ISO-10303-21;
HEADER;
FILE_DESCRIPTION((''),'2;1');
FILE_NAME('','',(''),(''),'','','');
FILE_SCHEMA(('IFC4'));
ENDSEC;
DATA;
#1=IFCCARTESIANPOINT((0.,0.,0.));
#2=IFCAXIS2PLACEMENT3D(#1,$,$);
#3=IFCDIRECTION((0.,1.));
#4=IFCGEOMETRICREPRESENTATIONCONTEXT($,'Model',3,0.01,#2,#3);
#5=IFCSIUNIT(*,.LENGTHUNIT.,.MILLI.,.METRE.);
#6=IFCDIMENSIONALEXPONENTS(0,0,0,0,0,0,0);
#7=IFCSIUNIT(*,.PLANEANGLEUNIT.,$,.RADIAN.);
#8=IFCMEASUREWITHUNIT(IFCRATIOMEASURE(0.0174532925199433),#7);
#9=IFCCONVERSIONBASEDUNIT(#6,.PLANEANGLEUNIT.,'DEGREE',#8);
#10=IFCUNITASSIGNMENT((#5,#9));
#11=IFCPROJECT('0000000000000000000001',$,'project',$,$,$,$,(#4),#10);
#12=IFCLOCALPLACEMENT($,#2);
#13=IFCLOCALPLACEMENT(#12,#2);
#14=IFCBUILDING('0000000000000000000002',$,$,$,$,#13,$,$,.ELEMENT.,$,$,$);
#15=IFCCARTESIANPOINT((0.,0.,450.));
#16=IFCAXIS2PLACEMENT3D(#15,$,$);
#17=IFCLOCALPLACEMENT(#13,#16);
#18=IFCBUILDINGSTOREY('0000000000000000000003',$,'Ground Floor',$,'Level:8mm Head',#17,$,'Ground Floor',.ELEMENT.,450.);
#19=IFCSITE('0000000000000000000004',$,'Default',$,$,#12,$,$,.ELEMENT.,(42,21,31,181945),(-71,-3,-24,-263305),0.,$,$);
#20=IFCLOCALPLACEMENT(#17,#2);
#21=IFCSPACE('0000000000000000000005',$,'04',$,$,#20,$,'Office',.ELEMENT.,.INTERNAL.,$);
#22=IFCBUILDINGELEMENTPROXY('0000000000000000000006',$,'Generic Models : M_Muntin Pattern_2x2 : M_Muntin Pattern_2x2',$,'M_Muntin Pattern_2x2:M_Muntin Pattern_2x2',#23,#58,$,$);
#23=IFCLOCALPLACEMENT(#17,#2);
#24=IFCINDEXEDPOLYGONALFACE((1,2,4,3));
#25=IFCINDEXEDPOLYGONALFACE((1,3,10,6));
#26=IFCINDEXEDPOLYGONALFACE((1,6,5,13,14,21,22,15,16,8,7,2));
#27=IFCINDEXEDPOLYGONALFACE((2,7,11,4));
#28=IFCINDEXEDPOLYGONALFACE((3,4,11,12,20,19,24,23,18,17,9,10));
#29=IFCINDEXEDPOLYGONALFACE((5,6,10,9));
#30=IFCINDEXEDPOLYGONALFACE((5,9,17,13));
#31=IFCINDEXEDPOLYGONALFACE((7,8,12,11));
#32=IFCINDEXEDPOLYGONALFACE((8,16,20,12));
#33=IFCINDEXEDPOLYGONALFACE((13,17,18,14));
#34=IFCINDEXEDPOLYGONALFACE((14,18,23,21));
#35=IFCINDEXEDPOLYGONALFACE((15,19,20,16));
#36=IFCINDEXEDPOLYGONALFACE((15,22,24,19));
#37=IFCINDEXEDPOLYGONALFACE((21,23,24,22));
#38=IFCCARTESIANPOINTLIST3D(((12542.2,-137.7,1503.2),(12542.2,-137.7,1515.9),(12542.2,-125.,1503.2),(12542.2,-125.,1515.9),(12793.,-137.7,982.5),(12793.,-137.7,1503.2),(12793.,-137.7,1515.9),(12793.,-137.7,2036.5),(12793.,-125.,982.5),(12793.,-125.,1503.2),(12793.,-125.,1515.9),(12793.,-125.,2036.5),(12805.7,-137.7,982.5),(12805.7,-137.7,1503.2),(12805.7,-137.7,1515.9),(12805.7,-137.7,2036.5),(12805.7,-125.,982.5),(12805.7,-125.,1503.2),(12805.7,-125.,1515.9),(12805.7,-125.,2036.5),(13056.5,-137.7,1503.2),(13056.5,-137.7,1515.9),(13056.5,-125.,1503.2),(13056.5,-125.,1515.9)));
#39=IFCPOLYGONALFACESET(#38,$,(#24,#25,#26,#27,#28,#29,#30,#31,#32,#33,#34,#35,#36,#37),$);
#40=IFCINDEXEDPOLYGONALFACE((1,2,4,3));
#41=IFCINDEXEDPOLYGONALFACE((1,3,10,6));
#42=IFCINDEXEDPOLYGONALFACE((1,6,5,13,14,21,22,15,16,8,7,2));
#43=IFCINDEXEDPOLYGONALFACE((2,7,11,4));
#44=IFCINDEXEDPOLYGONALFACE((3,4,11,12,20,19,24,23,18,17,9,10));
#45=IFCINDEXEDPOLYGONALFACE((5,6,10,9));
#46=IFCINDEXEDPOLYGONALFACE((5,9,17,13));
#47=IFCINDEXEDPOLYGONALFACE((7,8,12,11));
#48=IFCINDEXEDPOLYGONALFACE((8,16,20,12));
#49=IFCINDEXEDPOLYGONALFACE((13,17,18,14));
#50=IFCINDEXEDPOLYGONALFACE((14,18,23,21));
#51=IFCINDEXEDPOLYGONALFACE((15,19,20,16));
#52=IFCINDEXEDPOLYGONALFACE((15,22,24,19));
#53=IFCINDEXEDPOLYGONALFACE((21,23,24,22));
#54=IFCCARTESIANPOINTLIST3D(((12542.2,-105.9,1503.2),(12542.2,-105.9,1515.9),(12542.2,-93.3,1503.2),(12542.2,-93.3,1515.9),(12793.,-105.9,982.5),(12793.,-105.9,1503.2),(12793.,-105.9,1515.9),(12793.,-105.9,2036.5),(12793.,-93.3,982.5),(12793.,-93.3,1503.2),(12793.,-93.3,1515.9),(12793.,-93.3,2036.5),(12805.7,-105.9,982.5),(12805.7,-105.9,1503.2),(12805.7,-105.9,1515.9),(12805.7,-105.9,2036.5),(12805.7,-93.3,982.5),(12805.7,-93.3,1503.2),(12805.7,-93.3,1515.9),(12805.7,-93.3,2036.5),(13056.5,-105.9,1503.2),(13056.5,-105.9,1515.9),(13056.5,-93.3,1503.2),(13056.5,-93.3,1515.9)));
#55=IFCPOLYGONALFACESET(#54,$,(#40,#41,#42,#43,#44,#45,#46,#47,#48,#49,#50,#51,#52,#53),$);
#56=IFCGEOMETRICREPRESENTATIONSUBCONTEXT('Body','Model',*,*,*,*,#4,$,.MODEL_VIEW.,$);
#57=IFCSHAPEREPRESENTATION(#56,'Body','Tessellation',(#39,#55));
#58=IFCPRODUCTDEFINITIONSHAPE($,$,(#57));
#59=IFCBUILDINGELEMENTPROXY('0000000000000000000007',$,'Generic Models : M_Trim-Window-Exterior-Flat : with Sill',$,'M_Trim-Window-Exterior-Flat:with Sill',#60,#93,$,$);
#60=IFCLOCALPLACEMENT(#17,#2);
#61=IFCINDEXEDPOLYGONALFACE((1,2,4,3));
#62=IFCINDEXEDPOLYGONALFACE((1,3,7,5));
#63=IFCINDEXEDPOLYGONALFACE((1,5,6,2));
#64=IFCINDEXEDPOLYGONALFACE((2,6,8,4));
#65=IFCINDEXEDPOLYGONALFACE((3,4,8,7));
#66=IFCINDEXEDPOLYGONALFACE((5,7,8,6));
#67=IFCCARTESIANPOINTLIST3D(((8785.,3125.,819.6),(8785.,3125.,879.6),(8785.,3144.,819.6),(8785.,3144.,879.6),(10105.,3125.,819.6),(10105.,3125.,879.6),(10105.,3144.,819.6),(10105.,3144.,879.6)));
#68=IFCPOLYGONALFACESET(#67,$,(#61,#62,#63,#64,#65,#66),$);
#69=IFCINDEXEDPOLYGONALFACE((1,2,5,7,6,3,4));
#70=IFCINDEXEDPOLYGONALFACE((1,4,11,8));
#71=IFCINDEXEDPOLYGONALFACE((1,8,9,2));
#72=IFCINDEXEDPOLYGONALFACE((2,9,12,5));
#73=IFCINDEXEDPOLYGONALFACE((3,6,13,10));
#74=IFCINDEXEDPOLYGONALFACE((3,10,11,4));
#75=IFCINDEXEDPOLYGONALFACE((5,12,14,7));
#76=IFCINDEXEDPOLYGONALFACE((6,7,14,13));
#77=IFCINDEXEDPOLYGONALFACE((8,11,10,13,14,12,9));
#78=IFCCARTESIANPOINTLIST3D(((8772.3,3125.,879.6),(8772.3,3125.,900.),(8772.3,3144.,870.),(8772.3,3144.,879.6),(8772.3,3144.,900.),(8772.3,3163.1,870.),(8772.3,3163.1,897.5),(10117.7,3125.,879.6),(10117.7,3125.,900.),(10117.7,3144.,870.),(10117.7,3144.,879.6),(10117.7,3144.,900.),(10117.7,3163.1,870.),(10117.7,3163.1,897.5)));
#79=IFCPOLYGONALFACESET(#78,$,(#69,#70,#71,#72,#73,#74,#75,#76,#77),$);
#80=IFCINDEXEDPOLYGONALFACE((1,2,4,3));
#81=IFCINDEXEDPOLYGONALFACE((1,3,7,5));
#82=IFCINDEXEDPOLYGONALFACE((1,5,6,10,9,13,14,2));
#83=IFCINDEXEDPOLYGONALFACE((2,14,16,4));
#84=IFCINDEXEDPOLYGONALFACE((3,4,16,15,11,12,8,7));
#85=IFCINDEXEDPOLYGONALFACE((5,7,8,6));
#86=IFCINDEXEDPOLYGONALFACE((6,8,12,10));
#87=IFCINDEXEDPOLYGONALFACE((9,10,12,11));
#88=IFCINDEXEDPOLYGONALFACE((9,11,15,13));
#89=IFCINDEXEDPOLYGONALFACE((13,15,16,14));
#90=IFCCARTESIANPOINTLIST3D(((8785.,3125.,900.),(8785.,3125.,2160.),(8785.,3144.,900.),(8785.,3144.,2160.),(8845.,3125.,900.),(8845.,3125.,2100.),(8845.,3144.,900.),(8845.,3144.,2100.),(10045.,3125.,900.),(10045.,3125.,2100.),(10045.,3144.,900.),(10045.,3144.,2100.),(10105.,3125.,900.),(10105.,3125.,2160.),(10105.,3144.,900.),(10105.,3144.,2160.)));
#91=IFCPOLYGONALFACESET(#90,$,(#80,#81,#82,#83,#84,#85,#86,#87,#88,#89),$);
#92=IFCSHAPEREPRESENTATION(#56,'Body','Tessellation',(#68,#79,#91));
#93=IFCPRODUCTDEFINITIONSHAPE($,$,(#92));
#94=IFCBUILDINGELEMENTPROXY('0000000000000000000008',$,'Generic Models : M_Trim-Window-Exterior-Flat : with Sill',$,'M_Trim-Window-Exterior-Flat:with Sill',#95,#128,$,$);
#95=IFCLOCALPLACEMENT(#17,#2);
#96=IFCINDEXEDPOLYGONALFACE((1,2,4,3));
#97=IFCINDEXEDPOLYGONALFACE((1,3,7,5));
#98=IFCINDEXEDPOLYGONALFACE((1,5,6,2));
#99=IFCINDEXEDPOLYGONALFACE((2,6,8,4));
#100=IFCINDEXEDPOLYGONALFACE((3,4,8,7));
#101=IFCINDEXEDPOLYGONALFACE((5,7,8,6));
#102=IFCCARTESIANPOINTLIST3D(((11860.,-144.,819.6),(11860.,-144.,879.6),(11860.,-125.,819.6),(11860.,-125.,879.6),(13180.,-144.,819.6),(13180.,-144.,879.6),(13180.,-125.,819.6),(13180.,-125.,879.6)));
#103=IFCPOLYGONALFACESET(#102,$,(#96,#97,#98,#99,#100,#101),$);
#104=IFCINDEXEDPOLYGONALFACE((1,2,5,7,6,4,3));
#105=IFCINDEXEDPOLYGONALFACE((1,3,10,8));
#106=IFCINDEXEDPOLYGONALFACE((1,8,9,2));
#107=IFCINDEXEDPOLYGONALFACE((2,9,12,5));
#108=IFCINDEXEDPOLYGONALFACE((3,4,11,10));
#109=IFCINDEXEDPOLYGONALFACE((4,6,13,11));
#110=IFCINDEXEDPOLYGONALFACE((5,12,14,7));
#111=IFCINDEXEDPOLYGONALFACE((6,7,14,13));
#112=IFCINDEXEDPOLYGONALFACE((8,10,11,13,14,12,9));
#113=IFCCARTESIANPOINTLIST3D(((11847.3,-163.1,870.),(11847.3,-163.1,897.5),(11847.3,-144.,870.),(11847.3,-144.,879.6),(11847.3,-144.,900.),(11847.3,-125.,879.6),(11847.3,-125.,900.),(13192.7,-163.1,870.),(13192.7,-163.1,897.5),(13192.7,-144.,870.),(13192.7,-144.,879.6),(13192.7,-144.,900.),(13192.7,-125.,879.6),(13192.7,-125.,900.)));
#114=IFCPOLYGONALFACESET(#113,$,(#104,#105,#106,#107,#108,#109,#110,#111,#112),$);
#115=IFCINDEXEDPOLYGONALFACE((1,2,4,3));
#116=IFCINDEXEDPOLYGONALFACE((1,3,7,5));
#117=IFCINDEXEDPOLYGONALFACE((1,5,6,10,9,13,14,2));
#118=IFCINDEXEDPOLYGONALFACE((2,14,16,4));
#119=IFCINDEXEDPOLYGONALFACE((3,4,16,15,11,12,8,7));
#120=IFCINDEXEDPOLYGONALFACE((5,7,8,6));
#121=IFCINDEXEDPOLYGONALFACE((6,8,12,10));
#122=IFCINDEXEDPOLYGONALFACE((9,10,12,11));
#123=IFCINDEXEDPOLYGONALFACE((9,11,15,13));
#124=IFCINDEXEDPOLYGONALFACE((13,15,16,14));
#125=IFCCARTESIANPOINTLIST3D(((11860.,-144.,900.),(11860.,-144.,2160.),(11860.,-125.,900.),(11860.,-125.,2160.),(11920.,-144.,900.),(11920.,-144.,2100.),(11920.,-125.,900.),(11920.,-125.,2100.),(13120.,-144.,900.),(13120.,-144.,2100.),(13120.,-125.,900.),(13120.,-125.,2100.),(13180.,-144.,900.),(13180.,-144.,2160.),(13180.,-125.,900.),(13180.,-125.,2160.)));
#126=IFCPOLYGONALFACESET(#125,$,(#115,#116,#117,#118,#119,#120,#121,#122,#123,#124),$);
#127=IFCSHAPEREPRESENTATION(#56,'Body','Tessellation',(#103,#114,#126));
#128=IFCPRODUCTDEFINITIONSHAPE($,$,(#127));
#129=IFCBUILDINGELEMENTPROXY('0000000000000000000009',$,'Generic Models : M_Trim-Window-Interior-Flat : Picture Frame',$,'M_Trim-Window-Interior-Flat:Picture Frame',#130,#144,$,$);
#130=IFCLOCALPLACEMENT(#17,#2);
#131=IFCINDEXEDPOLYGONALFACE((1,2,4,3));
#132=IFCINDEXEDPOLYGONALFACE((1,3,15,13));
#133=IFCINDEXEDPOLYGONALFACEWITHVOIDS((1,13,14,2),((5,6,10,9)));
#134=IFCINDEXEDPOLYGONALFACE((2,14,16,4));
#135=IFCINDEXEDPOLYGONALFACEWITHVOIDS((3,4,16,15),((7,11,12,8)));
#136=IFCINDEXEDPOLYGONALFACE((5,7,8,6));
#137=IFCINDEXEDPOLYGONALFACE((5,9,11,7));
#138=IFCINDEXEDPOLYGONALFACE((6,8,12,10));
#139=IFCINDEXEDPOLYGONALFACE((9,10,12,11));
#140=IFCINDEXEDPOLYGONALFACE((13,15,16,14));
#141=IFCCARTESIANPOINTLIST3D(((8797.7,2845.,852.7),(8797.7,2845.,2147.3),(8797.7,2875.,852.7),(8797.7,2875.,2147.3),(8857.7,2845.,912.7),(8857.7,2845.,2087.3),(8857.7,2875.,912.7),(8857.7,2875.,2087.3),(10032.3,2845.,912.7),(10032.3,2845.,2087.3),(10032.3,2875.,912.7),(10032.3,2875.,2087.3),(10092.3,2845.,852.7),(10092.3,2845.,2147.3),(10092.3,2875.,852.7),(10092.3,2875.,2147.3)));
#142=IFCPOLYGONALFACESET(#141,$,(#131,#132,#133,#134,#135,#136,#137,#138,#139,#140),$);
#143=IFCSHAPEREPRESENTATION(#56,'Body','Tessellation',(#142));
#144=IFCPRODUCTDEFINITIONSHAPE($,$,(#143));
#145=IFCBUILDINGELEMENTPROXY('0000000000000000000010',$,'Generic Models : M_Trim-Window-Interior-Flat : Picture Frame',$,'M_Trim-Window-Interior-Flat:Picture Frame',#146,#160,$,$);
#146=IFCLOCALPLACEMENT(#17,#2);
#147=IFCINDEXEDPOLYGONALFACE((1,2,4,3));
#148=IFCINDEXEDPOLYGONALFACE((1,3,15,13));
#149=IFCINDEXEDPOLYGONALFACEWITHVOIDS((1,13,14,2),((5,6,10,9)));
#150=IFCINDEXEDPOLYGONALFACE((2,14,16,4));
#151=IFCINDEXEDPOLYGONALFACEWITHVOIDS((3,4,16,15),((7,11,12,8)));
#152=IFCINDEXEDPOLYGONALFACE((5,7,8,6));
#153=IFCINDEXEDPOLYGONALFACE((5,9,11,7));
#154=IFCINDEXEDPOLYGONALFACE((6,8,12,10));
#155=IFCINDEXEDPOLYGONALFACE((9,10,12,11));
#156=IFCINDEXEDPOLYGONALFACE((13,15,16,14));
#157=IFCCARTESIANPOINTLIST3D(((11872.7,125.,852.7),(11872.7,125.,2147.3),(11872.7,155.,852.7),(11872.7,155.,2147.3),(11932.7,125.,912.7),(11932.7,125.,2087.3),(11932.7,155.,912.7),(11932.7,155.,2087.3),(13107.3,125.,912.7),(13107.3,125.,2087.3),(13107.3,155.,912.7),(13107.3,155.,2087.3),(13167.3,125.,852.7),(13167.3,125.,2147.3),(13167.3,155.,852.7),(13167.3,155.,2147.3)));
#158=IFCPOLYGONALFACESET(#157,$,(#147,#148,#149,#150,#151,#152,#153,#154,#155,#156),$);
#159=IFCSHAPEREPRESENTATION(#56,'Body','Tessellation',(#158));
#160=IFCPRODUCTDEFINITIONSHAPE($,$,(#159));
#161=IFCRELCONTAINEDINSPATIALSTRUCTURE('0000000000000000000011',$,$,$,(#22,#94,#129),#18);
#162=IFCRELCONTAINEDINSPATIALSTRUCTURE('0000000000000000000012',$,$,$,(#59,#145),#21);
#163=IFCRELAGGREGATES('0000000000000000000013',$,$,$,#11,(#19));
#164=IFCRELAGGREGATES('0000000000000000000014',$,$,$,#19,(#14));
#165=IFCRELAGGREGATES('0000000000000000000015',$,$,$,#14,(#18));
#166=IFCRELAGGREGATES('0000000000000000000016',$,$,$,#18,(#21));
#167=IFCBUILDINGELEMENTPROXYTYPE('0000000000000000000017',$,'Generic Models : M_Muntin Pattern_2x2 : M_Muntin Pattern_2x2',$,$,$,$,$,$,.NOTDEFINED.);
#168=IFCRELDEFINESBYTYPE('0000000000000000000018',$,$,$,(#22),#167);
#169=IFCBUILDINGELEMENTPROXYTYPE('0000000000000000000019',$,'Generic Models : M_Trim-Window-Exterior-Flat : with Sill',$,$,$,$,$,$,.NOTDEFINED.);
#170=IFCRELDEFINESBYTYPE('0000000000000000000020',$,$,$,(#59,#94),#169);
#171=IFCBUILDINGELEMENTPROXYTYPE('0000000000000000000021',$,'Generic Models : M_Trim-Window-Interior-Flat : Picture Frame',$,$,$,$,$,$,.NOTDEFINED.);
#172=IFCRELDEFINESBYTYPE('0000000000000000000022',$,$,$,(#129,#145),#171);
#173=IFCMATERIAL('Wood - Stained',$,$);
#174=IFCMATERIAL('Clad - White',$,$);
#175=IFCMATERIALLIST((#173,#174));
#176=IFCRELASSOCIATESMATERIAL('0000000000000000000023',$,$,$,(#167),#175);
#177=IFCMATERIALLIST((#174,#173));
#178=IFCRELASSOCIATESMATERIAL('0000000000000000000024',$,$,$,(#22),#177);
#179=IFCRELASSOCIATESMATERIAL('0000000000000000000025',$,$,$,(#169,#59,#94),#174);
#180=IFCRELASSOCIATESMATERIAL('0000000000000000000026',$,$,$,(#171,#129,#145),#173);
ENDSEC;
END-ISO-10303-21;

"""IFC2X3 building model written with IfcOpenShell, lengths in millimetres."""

from ifc_helpers import new_model, entity, si_unit, converted_unit, direction, frame, frame_2d, origin, place, context, subcontext, project, spatial, polyline, rectangle, outline, extrude, source, transform, mapped, material, material_list, type_object, type_shapes, element, save


model = new_model("IFC2X3")

# Units and contexts
model_context = context("Model", 3, precision=0.01, world=origin(), true_north=direction((0.0, 1.0)))
body_context = subcontext(model_context, "Body", "Model", "MODEL_VIEW")
ifc_project = project(units=[si_unit("LENGTHUNIT", "METRE", prefix="MILLI"), converted_unit("PLANEANGLEUNIT", "DEGREE", entity("IfcRatioMeasure", 0.0174532925199433), si_unit("PLANEANGLEUNIT", "RADIAN"), dimensions=[0, 0, 0, 0, 0, 0, 0])], contexts=[model_context])

# Site, building, storey
site_placement = place(None, origin())
site = spatial("IfcSite", under=ifc_project, at=site_placement, Name="Default", CompositionType="ELEMENT", RefLatitude=(42, 21, 31, 181945), RefLongitude=(-71, -3, -24, -263305), RefElevation=0.0)
building_placement = place(site_placement, origin())
building = spatial("IfcBuilding", under=site, at=building_placement, CompositionType="ELEMENT")
storey_placement = place(building_placement, frame((0.0, 0.0, 450.0)))
storey = spatial("IfcBuildingStorey", under=building, at=storey_placement, Name="Ground Floor", ObjectType="Level:8mm Head", LongName="Ground Floor", CompositionType="ELEMENT", Elevation=450.0)

# Building element proxy
ifc_material_1 = material(Name="Clad - White")
ifc_material_2 = material(Name="Wood - Stained")
ifc_material_list_1 = material_list([ifc_material_2, ifc_material_1])
building_element_proxy_type_1 = type_object("IfcBuildingElementProxyType", Name="Generic Models : M_Muntin Pattern_2x2 : M_Muntin Pattern_2x2", PredefinedType="NOTDEFINED", material=ifc_material_list_1)
shared_shape_1 = source(origin(), body_context, "Body", "SweptSolid", [
    extrude(outline(polyline([(6.4, -6.4), (527.0, -6.4), (527.0, 6.3), (6.4, 6.3), (6.4, 257.1), (-6.3, 257.1), (-6.3, 6.3), (-527.0, 6.3), (-527.0, -6.4), (-6.3, -6.4), (-6.3, -257.1), (6.4, -257.1), (6.4, -6.4)])), frame((0.0, 9.5, 527.0), z_axis=(0.0, 1.0, 0.0), x_axis=(0.0, 0.0, 1.0)), (0.0, 0.0, 1.0), 12.7),
    extrude(outline(polyline([(6.4, -6.4), (527.0, -6.4), (527.0, 6.3), (6.4, 6.3), (6.4, 257.1), (-6.3, 257.1), (-6.3, 6.3), (-527.0, 6.3), (-527.0, -6.4), (-6.3, -6.4), (-6.3, -257.1), (6.4, -257.1), (6.4, -6.4)])), frame((0.0, -22.2, 527.0), z_axis=(0.0, 1.0, 0.0), x_axis=(0.0, 0.0, 1.0)), (0.0, 0.0, 1.0), 12.7),
])
type_shapes(building_element_proxy_type_1, [shared_shape_1])
ifc_material_list_2 = material_list([ifc_material_1, ifc_material_2])
proxy_1_placement = place(storey_placement, frame((12799.4, -115.5, 982.5), z_axis=(0.0, 0.0, 1.0), x_axis=(-1.0, 0.0, 0.0)))
element("IfcBuildingElementProxy", 1, at=proxy_1_placement, inside=storey, type_object=building_element_proxy_type_1, material=ifc_material_list_2, Name="Generic Models : M_Muntin Pattern_2x2 : M_Muntin Pattern_2x2", ObjectType="M_Muntin Pattern_2x2:M_Muntin Pattern_2x2", context=body_context, shape_type="MappedRepresentation", body=[
    mapped(shared_shape_1, transform((0.0, 0.0, 0.0), scale=1.0)),
])

# Shared definitions
space_placement = place(storey_placement, origin())
space = spatial("IfcSpace", under=storey, at=space_placement, Name="04", LongName="Office", CompositionType="ELEMENT", InteriorOrExteriorSpace="INTERNAL")

# Building element proxies
building_element_proxy_type_2 = type_object("IfcBuildingElementProxyType", Name="Generic Models : M_Trim-Window-Exterior-Flat : with Sill", PredefinedType="NOTDEFINED", material=ifc_material_1)
shared_shape_2 = source(origin(), body_context, "Body", "SweptSolid", [
    extrude(rectangle(XDim=1320.0, YDim=60.0, at=frame_2d((0.0, 0.0), x_axis=(1.0, 0.0))), frame((0.0, -1250.4, 0.0), z_axis=(0.0, 0.0, 1.0), x_axis=(-1.0, 0.0, 0.0)), (0.0, 0.0, 1.0), 19.1),
    extrude(outline(polyline([(-19.0, -15.2), (0.0, -15.2), (0.0, -5.7), (19.0, -5.7), (19.0, 14.8), (0.0, 14.8), (-19.0, 12.3), (-19.0, -15.2)])), frame((-672.7, -1214.8, 19.0), z_axis=(1.0, 0.0, 0.0), x_axis=(0.0, 0.0, -1.0)), (0.0, 0.0, 1.0), 1345.4),
    extrude(outline(polyline([(-645.0, -660.0), (615.0, -660.0), (615.0, -600.0), (-585.0, -600.0), (-585.0, 600.0), (615.0, 600.0), (615.0, 660.0), (-645.0, 660.0), (-645.0, -660.0)])), frame((0.0, -585.0, 0.0), z_axis=(0.0, 0.0, 1.0), x_axis=(0.0, -1.0, 0.0)), (0.0, 0.0, 1.0), 19.1),
])
type_shapes(building_element_proxy_type_2, [shared_shape_2])
proxy_2_placement = place(space_placement, frame((9445.0, 3125.0, 2100.0), z_axis=(0.0, 1.0, 0.0), x_axis=(-1.0, 0.0, 0.0)))
element("IfcBuildingElementProxy", 2, at=proxy_2_placement, inside=space, type_object=building_element_proxy_type_2, material=ifc_material_1, Name="Generic Models : M_Trim-Window-Exterior-Flat : with Sill", ObjectType="M_Trim-Window-Exterior-Flat:with Sill", context=body_context, shape_type="MappedRepresentation", body=[
    mapped(shared_shape_2, transform((0.0, 0.0, 0.0), scale=1.0)),
])
proxy_3_placement = place(storey_placement, frame((12520.0, -125.0, 2100.0), z_axis=(0.0, -1.0, 0.0), x_axis=(1.0, 0.0, 0.0)))
element("IfcBuildingElementProxy", 3, at=proxy_3_placement, inside=storey, type_object=building_element_proxy_type_2, material=ifc_material_1, Name="Generic Models : M_Trim-Window-Exterior-Flat : with Sill", ObjectType="M_Trim-Window-Exterior-Flat:with Sill", context=body_context, shape_type="MappedRepresentation", body=[
    mapped(shared_shape_2, transform((0.0, 0.0, 0.0), scale=1.0)),
])
building_element_proxy_type_3 = type_object("IfcBuildingElementProxyType", Name="Generic Models : M_Trim-Window-Interior-Flat : Picture Frame", PredefinedType="NOTDEFINED", material=ifc_material_2)
shared_shape_3 = source(origin(), body_context, "Body", "SweptSolid", [
    extrude(outline(polyline([(-647.3, -647.3), (647.3, -647.3), (647.3, 647.3), (-647.3, 647.3), (-647.3, -647.3)]), holes=[polyline([(-587.3, -587.3), (-587.3, 587.3), (587.3, 587.3), (587.3, -587.3), (-587.3, -587.3)])]), frame((0.0, -600.0, 0.0), z_axis=(0.0, 0.0, 1.0), x_axis=(-1.0, 0.0, 0.0)), (0.0, 0.0, 1.0), 30.0),
])
type_shapes(building_element_proxy_type_3, [shared_shape_3])
proxy_4_placement = place(storey_placement, frame((9445.0, 2875.0, 2100.0), z_axis=(0.0, -1.0, 0.0), x_axis=(1.0, 0.0, 0.0)))
element("IfcBuildingElementProxy", 4, at=proxy_4_placement, inside=storey, type_object=building_element_proxy_type_3, material=ifc_material_2, Name="Generic Models : M_Trim-Window-Interior-Flat : Picture Frame", ObjectType="M_Trim-Window-Interior-Flat:Picture Frame", context=body_context, shape_type="MappedRepresentation", body=[
    mapped(shared_shape_3, transform((0.0, 0.0, 0.0), scale=1.0)),
])
proxy_5_placement = place(space_placement, frame((12520.0, 125.0, 2100.0), z_axis=(0.0, 1.0, 0.0), x_axis=(-1.0, 0.0, 0.0)))
element("IfcBuildingElementProxy", 5, at=proxy_5_placement, inside=space, type_object=building_element_proxy_type_3, material=ifc_material_2, Name="Generic Models : M_Trim-Window-Interior-Flat : Picture Frame", ObjectType="M_Trim-Window-Interior-Flat:Picture Frame", context=body_context, shape_type="MappedRepresentation", body=[
    mapped(shared_shape_3, transform((0.0, 0.0, 0.0), scale=1.0)),
])

save(model, "model.ifc")
